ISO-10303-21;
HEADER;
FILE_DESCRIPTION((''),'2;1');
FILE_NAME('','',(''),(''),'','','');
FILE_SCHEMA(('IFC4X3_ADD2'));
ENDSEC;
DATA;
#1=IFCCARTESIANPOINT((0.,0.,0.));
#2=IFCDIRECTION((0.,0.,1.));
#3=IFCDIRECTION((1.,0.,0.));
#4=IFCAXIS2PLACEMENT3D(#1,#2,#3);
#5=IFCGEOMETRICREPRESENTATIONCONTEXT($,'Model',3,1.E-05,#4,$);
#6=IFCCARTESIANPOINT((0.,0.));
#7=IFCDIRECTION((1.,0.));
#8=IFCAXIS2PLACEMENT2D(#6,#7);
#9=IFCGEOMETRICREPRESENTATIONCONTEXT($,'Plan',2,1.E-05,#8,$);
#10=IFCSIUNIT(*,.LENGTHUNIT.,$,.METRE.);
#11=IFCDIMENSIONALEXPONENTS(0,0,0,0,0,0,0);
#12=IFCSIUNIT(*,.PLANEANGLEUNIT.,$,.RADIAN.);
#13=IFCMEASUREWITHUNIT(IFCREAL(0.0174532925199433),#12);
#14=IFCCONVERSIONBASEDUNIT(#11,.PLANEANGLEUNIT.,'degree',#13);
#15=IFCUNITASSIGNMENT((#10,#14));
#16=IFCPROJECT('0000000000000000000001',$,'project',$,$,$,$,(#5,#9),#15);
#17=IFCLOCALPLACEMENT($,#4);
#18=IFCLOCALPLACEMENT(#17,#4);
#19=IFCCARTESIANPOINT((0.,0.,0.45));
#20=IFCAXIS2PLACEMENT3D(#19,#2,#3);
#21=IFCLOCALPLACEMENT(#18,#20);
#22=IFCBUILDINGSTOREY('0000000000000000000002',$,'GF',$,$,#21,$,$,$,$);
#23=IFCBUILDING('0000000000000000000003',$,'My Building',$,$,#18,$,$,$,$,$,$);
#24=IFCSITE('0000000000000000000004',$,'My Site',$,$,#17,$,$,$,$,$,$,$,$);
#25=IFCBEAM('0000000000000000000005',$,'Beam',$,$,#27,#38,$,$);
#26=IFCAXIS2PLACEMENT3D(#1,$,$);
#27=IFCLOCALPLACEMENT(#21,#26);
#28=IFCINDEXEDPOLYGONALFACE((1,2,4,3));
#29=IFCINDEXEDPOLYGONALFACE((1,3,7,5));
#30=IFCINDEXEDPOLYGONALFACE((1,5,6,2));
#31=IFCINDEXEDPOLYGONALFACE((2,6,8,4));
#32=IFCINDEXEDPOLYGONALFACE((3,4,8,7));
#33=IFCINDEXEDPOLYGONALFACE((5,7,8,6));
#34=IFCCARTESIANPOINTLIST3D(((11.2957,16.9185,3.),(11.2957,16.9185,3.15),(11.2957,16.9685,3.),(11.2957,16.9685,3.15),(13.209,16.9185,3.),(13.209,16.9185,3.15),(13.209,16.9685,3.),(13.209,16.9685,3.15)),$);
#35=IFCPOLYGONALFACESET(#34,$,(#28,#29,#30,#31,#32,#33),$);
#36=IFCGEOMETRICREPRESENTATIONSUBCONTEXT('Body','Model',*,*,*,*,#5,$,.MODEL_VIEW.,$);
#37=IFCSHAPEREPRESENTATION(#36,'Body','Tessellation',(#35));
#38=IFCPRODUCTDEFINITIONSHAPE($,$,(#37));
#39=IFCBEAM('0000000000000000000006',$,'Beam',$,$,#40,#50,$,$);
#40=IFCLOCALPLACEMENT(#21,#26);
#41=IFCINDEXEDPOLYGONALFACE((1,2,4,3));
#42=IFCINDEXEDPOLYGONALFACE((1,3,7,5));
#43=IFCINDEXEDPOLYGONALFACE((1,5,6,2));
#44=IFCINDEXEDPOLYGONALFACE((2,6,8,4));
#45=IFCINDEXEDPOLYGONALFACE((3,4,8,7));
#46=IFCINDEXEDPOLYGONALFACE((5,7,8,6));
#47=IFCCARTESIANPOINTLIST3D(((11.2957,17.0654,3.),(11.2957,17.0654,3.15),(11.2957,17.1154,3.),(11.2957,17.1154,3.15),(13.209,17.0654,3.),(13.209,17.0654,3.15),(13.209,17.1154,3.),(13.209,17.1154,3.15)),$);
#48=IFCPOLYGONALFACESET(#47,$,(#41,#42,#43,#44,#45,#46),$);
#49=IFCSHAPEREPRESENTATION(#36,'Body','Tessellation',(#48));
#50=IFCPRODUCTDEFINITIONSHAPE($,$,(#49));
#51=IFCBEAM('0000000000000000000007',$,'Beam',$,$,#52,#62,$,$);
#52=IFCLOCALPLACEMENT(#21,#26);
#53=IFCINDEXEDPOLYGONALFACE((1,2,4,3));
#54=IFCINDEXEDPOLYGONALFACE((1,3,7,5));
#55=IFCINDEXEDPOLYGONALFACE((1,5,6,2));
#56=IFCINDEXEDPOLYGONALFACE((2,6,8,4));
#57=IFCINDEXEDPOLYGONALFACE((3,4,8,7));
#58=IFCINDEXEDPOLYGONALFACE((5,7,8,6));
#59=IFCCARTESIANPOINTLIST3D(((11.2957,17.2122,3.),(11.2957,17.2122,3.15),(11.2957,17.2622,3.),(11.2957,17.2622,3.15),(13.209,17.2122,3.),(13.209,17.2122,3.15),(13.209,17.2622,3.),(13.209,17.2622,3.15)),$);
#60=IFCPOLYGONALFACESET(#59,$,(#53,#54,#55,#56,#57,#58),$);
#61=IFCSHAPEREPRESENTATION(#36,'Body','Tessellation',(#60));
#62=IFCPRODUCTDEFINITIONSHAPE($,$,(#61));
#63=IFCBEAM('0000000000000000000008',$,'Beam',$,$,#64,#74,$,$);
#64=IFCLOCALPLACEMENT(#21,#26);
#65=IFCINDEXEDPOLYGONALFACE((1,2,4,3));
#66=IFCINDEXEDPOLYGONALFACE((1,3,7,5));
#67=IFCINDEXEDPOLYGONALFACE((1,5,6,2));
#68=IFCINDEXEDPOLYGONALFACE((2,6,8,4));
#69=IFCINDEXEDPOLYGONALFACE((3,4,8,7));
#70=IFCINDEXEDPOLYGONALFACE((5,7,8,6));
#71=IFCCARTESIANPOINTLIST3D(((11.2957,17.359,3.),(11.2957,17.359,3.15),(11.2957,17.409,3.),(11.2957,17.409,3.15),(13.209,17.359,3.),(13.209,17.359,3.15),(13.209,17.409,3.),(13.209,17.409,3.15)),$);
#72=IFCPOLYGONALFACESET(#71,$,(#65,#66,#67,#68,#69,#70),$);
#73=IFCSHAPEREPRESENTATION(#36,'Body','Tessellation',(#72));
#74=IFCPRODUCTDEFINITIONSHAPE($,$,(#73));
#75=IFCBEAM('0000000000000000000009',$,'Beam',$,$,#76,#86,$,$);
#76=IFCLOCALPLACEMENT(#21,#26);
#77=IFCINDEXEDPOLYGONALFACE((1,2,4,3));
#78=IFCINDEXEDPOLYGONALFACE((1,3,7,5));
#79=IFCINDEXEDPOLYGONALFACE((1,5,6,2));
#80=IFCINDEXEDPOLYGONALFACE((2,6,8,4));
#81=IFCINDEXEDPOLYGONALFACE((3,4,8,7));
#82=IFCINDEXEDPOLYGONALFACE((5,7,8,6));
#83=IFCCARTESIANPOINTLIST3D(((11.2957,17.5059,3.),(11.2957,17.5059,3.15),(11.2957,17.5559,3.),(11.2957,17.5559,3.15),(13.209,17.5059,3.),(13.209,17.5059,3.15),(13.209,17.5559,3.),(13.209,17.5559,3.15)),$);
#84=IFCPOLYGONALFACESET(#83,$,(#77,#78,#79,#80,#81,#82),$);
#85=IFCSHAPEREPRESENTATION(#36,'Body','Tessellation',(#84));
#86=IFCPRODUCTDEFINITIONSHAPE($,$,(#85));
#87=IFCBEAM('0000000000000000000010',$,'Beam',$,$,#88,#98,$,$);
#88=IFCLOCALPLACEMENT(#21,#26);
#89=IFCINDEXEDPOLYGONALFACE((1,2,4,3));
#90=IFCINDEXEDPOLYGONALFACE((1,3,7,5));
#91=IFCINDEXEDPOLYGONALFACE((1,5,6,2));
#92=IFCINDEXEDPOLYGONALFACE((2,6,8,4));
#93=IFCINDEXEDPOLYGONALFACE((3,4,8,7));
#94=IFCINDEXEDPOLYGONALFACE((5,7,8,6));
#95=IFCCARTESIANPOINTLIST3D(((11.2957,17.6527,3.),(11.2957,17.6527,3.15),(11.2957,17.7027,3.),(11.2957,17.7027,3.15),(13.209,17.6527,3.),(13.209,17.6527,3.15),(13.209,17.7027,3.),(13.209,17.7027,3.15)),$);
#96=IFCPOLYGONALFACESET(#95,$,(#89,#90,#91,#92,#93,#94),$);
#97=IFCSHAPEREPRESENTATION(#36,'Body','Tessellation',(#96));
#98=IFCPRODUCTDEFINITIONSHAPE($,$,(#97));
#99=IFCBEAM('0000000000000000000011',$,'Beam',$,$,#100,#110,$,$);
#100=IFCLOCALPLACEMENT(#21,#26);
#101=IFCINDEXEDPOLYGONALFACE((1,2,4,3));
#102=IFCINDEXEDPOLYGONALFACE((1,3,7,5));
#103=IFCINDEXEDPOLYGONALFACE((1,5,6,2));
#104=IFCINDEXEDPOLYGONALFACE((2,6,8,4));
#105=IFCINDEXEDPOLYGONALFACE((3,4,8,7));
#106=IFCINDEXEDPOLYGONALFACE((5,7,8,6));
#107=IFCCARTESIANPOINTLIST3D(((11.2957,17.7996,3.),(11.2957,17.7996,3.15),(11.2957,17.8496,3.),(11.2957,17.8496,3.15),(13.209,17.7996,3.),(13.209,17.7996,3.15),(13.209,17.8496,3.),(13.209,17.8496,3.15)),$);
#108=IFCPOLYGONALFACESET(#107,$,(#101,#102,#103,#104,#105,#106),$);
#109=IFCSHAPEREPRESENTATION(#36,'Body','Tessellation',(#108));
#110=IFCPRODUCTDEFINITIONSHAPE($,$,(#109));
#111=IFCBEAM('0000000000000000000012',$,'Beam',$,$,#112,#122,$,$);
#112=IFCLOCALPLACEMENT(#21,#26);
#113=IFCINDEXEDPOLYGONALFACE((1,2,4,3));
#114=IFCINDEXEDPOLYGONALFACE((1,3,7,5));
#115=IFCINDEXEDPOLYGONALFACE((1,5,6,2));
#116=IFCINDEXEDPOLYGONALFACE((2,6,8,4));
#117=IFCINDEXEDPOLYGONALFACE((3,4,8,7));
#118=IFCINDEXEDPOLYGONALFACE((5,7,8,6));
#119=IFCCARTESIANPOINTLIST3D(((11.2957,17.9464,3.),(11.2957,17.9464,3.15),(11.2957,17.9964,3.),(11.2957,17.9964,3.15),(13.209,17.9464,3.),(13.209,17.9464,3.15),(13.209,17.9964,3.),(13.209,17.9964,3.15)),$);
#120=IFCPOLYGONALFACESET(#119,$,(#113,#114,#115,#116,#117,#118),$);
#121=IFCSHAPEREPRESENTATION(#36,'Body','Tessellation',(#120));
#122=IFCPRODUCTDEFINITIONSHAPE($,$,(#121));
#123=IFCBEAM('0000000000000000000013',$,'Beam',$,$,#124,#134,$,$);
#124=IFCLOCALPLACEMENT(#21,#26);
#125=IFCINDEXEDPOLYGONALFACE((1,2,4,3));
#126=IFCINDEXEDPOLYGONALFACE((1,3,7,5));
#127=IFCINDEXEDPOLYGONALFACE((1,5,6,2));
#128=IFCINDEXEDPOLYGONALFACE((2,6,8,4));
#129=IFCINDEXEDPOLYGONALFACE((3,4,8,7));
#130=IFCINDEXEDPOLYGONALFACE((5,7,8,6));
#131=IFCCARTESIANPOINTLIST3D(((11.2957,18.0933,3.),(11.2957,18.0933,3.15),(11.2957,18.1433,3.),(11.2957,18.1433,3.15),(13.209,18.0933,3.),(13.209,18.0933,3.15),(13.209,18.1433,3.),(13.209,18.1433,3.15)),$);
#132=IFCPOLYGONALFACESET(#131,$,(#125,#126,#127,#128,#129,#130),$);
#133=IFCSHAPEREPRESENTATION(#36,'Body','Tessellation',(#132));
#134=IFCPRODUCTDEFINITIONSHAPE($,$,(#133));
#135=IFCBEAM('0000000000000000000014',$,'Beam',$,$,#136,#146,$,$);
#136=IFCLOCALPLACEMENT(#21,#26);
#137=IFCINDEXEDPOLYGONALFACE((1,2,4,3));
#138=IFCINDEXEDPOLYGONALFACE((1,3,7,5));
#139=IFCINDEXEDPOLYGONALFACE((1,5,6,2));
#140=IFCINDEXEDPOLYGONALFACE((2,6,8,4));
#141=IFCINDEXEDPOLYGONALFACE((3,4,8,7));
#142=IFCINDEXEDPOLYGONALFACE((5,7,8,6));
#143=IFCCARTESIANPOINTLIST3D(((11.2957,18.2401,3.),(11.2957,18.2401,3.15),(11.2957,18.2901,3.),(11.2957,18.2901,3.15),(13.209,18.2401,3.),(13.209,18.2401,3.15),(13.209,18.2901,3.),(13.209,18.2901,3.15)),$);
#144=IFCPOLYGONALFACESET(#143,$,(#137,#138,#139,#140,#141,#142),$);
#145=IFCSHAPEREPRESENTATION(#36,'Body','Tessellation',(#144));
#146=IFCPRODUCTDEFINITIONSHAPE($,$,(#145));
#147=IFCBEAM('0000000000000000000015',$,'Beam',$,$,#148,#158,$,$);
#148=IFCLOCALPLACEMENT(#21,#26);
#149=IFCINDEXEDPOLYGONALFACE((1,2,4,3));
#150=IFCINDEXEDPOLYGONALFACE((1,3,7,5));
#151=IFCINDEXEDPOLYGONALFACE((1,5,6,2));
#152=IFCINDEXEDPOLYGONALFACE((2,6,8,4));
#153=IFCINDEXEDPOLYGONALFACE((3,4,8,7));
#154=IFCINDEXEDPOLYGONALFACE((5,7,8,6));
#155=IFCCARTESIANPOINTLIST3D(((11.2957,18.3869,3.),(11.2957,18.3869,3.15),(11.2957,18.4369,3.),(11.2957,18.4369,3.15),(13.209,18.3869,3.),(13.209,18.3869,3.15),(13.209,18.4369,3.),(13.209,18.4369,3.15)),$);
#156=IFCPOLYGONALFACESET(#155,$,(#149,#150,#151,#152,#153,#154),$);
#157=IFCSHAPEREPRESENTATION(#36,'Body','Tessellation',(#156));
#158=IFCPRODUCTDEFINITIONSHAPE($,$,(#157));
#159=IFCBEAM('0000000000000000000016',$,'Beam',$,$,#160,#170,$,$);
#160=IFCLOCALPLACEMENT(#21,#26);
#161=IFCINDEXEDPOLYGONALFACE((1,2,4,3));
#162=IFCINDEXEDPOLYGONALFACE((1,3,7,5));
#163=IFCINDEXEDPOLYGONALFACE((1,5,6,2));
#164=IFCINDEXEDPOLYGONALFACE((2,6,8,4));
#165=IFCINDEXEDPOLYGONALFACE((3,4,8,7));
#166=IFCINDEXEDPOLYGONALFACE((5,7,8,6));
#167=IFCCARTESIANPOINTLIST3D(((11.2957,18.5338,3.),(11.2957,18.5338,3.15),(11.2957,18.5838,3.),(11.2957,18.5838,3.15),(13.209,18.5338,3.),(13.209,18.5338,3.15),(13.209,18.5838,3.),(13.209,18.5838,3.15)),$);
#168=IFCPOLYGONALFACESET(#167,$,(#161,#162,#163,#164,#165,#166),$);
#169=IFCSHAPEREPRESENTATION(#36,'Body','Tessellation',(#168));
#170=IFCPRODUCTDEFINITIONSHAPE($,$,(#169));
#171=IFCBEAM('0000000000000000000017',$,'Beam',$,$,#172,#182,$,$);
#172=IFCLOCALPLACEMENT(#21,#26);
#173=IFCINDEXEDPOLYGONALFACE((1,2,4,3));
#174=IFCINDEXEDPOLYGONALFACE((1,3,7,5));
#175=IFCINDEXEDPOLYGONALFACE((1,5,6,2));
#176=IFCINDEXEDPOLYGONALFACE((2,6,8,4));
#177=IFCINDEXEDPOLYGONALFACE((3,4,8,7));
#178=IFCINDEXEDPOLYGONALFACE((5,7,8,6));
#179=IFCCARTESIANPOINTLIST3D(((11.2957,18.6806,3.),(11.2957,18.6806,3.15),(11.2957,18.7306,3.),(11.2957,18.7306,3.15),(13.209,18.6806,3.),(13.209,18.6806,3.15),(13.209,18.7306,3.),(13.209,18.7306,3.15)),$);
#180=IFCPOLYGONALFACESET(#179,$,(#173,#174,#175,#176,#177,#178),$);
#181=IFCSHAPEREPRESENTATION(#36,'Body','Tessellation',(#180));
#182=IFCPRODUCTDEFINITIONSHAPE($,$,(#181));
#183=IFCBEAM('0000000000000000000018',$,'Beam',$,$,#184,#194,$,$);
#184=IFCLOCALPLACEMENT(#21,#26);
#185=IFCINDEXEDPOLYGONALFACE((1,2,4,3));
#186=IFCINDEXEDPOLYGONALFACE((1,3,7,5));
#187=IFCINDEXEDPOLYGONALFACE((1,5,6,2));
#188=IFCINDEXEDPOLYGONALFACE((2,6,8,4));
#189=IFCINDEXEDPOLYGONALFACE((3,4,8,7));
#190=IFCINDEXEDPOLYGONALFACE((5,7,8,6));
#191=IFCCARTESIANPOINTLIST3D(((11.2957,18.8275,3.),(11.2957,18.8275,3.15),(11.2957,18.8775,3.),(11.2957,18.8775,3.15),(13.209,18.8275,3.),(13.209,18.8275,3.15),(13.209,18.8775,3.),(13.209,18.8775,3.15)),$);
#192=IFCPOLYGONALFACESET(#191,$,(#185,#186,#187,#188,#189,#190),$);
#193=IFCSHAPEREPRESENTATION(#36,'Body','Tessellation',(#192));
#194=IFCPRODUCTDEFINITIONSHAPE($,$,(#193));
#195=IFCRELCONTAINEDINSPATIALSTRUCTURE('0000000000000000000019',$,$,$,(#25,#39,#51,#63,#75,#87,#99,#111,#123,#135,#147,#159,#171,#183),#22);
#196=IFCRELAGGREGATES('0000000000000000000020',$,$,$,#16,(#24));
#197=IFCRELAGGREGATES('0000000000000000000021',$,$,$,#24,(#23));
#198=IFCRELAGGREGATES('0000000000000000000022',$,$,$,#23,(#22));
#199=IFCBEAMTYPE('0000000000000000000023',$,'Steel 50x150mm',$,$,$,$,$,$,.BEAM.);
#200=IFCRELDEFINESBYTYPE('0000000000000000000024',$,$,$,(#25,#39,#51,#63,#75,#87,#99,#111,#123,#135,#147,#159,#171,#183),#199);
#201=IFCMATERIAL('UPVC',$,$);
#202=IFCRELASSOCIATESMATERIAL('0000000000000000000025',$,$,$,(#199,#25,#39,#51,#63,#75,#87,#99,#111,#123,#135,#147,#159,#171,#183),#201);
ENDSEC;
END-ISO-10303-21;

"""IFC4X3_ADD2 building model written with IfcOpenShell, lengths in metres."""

from ifc_helpers import new_model, entity, si_unit, converted_unit, frame, origin_with_axes, origin_2d_with_axis, place, context, subcontext, project, spatial, rectangle, extrude, material, material_profile, profile_set, profile_usage, type_object, element, save


model = new_model("IFC4X3_ADD2")

# Units and contexts
model_context = context("Model", 3, precision=1e-05, world=origin_with_axes())
plan_context = context("Plan", 2, precision=1e-05, world=origin_2d_with_axis())
body_context = subcontext(model_context, "Body", "Model", "MODEL_VIEW")
ifc_project = project(units=[si_unit("LENGTHUNIT", "METRE"), converted_unit("PLANEANGLEUNIT", "degree", entity("IfcReal", 0.0174532925199433), si_unit("PLANEANGLEUNIT", "RADIAN"), dimensions=[0, 0, 0, 0, 0, 0, 0])], contexts=[model_context, plan_context])

# Site, building, storey
site_placement = place(None, origin_with_axes())
site = spatial("IfcSite", under=ifc_project, at=site_placement, Name="My Site")
building_placement = place(site_placement, origin_with_axes())
building = spatial("IfcBuilding", under=site, at=building_placement, Name="My Building")
storey_placement = place(building_placement, frame((0.0, 0.0, 0.45), z_axis=(0.0, 0.0, 1.0), x_axis=(1.0, 0.0, 0.0)))
storey = spatial("IfcBuildingStorey", under=building, at=storey_placement, Name="GF")

# Beams
ifc_material = material(Name="UPVC")
ifc_material_profile = material_profile(ifc_material, rectangle(XDim=0.05, YDim=0.15))
ifc_profile_set = profile_set([ifc_material_profile])
ifc_profile_usage_1 = profile_usage(ifc_profile_set)
beam_type = type_object("IfcBeamType", Name="Steel 50x150mm", PredefinedType="BEAM", material=ifc_profile_set)
beam_1_placement = place(storey_placement, frame((11.2957, 16.9435, 3.075), z_axis=(1.0, 0.0, 0.0), x_axis=(0.0, 1.0, 0.0)))
element("IfcBeam", 1, at=beam_1_placement, inside=storey, type_object=beam_type, material=ifc_profile_usage_1, Name="Beam", context=body_context, shape_type="SweptSolid", body=[
    extrude(rectangle(XDim=0.05, YDim=0.15), origin_with_axes(), (0.0, 0.0, 1.0), 1.9133),
])
ifc_profile_usage_2 = profile_usage(ifc_profile_set)
beam_2_placement = place(storey_placement, frame((11.2957, 17.0904, 3.075), z_axis=(1.0, 0.0, 0.0), x_axis=(0.0, 1.0, 0.0)))
element("IfcBeam", 2, at=beam_2_placement, inside=storey, type_object=beam_type, material=ifc_profile_usage_2, Name="Beam", context=body_context, shape_type="SweptSolid", body=[
    extrude(rectangle(XDim=0.05, YDim=0.15), origin_with_axes(), (0.0, 0.0, 1.0), 1.9133),
])
ifc_profile_usage_3 = profile_usage(ifc_profile_set)
beam_3_placement = place(storey_placement, frame((11.2957, 17.2372, 3.075), z_axis=(1.0, 0.0, 0.0), x_axis=(0.0, 1.0, 0.0)))
element("IfcBeam", 3, at=beam_3_placement, inside=storey, type_object=beam_type, material=ifc_profile_usage_3, Name="Beam", context=body_context, shape_type="SweptSolid", body=[
    extrude(rectangle(XDim=0.05, YDim=0.15), origin_with_axes(), (0.0, 0.0, 1.0), 1.9133),
])
ifc_profile_usage_4 = profile_usage(ifc_profile_set)
beam_4_placement = place(storey_placement, frame((11.2957, 17.384, 3.075), z_axis=(1.0, 0.0, 0.0), x_axis=(0.0, 1.0, 0.0)))
element("IfcBeam", 4, at=beam_4_placement, inside=storey, type_object=beam_type, material=ifc_profile_usage_4, Name="Beam", context=body_context, shape_type="SweptSolid", body=[
    extrude(rectangle(XDim=0.05, YDim=0.15), origin_with_axes(), (0.0, 0.0, 1.0), 1.9133),
])
ifc_profile_usage_5 = profile_usage(ifc_profile_set)
beam_5_placement = place(storey_placement, frame((11.2957, 17.5309, 3.075), z_axis=(1.0, 0.0, 0.0), x_axis=(0.0, 1.0, 0.0)))
element("IfcBeam", 5, at=beam_5_placement, inside=storey, type_object=beam_type, material=ifc_profile_usage_5, Name="Beam", context=body_context, shape_type="SweptSolid", body=[
    extrude(rectangle(XDim=0.05, YDim=0.15), origin_with_axes(), (0.0, 0.0, 1.0), 1.9133),
])
ifc_profile_usage_6 = profile_usage(ifc_profile_set)
beam_6_placement = place(storey_placement, frame((11.2957, 17.6777, 3.075), z_axis=(1.0, 0.0, 0.0), x_axis=(0.0, 1.0, 0.0)))
element("IfcBeam", 6, at=beam_6_placement, inside=storey, type_object=beam_type, material=ifc_profile_usage_6, Name="Beam", context=body_context, shape_type="SweptSolid", body=[
    extrude(rectangle(XDim=0.05, YDim=0.15), origin_with_axes(), (0.0, 0.0, 1.0), 1.9133),
])
ifc_profile_usage_7 = profile_usage(ifc_profile_set)
beam_7_placement = place(storey_placement, frame((11.2957, 17.8246, 3.075), z_axis=(1.0, 0.0, 0.0), x_axis=(0.0, 1.0, 0.0)))
element("IfcBeam", 7, at=beam_7_placement, inside=storey, type_object=beam_type, material=ifc_profile_usage_7, Name="Beam", context=body_context, shape_type="SweptSolid", body=[
    extrude(rectangle(XDim=0.05, YDim=0.15), origin_with_axes(), (0.0, 0.0, 1.0), 1.9133),
])
ifc_profile_usage_8 = profile_usage(ifc_profile_set)
beam_8_placement = place(storey_placement, frame((11.2957, 17.9714, 3.075), z_axis=(1.0, 0.0, 0.0), x_axis=(0.0, 1.0, 0.0)))
element("IfcBeam", 8, at=beam_8_placement, inside=storey, type_object=beam_type, material=ifc_profile_usage_8, Name="Beam", context=body_context, shape_type="SweptSolid", body=[
    extrude(rectangle(XDim=0.05, YDim=0.15), origin_with_axes(), (0.0, 0.0, 1.0), 1.9133),
])
ifc_profile_usage_9 = profile_usage(ifc_profile_set)
beam_9_placement = place(storey_placement, frame((11.2957, 18.1183, 3.075), z_axis=(1.0, 0.0, 0.0), x_axis=(0.0, 1.0, 0.0)))
element("IfcBeam", 9, at=beam_9_placement, inside=storey, type_object=beam_type, material=ifc_profile_usage_9, Name="Beam", context=body_context, shape_type="SweptSolid", body=[
    extrude(rectangle(XDim=0.05, YDim=0.15), origin_with_axes(), (0.0, 0.0, 1.0), 1.9133),
])
ifc_profile_usage_10 = profile_usage(ifc_profile_set)
beam_10_placement = place(storey_placement, frame((11.2957, 18.2651, 3.075), z_axis=(1.0, 0.0, 0.0), x_axis=(0.0, 1.0, 0.0)))
element("IfcBeam", 10, at=beam_10_placement, inside=storey, type_object=beam_type, material=ifc_profile_usage_10, Name="Beam", context=body_context, shape_type="SweptSolid", body=[
    extrude(rectangle(XDim=0.05, YDim=0.15), origin_with_axes(), (0.0, 0.0, 1.0), 1.9133),
])
ifc_profile_usage_11 = profile_usage(ifc_profile_set)
beam_11_placement = place(storey_placement, frame((11.2957, 18.4119, 3.075), z_axis=(1.0, 0.0, 0.0), x_axis=(0.0, 1.0, 0.0)))
element("IfcBeam", 11, at=beam_11_placement, inside=storey, type_object=beam_type, material=ifc_profile_usage_11, Name="Beam", context=body_context, shape_type="SweptSolid", body=[
    extrude(rectangle(XDim=0.05, YDim=0.15), origin_with_axes(), (0.0, 0.0, 1.0), 1.9133),
])
ifc_profile_usage_12 = profile_usage(ifc_profile_set)
beam_12_placement = place(storey_placement, frame((11.2957, 18.5588, 3.075), z_axis=(1.0, 0.0, 0.0), x_axis=(0.0, 1.0, 0.0)))
element("IfcBeam", 12, at=beam_12_placement, inside=storey, type_object=beam_type, material=ifc_profile_usage_12, Name="Beam", context=body_context, shape_type="SweptSolid", body=[
    extrude(rectangle(XDim=0.05, YDim=0.15), origin_with_axes(), (0.0, 0.0, 1.0), 1.9133),
])
ifc_profile_usage_13 = profile_usage(ifc_profile_set)
beam_13_placement = place(storey_placement, frame((11.2957, 18.7056, 3.075), z_axis=(1.0, 0.0, 0.0), x_axis=(0.0, 1.0, 0.0)))
element("IfcBeam", 13, at=beam_13_placement, inside=storey, type_object=beam_type, material=ifc_profile_usage_13, Name="Beam", context=body_context, shape_type="SweptSolid", body=[
    extrude(rectangle(XDim=0.05, YDim=0.15), origin_with_axes(), (0.0, 0.0, 1.0), 1.9133),
])
ifc_profile_usage_14 = profile_usage(ifc_profile_set)
beam_14_placement = place(storey_placement, frame((11.2957, 18.8525, 3.075), z_axis=(1.0, 0.0, 0.0), x_axis=(0.0, 1.0, 0.0)))
element("IfcBeam", 14, at=beam_14_placement, inside=storey, type_object=beam_type, material=ifc_profile_usage_14, Name="Beam", context=body_context, shape_type="SweptSolid", body=[
    extrude(rectangle(XDim=0.05, YDim=0.15), origin_with_axes(), (0.0, 0.0, 1.0), 1.9133),
])

save(model, "model.ifc")
